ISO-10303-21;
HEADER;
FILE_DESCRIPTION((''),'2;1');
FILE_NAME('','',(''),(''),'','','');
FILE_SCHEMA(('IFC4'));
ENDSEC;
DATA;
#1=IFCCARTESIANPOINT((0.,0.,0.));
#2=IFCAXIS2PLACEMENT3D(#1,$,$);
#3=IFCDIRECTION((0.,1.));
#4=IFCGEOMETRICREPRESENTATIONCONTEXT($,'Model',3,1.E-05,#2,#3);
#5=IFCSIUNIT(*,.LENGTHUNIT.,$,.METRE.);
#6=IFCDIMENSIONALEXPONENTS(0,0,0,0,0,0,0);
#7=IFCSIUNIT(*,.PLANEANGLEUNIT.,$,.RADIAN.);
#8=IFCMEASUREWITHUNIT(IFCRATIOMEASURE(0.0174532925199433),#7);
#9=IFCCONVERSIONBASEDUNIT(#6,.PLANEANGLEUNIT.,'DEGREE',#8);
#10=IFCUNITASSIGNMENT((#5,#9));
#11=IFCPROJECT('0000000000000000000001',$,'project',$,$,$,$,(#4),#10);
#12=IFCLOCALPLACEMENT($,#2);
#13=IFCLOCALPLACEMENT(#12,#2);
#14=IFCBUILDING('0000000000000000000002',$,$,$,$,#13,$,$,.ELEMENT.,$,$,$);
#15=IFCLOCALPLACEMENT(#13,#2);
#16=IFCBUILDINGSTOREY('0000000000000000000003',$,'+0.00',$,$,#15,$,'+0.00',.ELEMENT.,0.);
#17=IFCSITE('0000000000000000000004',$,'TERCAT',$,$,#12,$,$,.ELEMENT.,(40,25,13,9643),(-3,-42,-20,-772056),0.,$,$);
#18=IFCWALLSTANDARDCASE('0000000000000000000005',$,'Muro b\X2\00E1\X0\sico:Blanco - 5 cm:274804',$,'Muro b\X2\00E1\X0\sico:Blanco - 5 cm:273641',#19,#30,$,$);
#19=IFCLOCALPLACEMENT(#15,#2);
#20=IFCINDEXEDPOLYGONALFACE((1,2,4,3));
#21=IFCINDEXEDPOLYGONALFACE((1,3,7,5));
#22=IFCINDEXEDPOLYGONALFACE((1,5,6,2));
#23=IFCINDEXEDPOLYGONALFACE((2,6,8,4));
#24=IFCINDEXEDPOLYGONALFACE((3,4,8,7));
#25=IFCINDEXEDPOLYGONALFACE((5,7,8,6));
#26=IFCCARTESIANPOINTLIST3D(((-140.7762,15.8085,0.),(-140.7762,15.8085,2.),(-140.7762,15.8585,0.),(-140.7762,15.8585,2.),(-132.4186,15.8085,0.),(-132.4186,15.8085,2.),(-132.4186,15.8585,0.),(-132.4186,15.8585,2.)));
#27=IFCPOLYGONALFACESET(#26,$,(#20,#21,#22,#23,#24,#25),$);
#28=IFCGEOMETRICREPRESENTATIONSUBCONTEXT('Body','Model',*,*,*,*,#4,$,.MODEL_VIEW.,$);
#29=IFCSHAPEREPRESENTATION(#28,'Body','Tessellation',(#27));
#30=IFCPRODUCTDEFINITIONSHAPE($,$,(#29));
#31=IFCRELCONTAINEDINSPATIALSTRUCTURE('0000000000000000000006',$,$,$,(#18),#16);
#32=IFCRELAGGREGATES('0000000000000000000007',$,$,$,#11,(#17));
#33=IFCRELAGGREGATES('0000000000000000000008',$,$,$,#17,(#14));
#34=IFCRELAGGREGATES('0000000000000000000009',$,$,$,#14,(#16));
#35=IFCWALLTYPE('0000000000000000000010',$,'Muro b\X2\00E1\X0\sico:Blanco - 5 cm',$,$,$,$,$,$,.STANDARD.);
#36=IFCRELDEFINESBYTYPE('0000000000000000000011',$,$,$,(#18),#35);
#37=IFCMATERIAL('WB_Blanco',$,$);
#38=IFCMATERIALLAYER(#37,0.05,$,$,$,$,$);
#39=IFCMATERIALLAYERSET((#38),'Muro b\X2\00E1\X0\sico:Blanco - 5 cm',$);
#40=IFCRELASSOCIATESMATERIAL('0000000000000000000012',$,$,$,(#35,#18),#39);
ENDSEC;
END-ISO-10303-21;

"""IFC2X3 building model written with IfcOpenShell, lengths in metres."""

from ifc_helpers import new_model, entity, si_unit, converted_unit, direction, frame, frame_2d, origin, place, context, subcontext, project, spatial, rectangle, extrude, material, layer, layer_set, layer_usage, type_object, element, save


model = new_model("IFC2X3")

# Units and contexts
model_context = context("Model", 3, precision=1e-05, world=origin(), true_north=direction((0.0, 1.0)))
body_context = subcontext(model_context, "Body", "Model", "MODEL_VIEW")
ifc_project = project(units=[si_unit("LENGTHUNIT", "METRE"), converted_unit("PLANEANGLEUNIT", "DEGREE", entity("IfcRatioMeasure", 0.0174532925199433), si_unit("PLANEANGLEUNIT", "RADIAN"), dimensions=[0, 0, 0, 0, 0, 0, 0])], contexts=[model_context])

# Site, building, storey
site_placement = place(None, origin())
site = spatial("IfcSite", under=ifc_project, at=site_placement, Name="TERCAT", CompositionType="ELEMENT", RefLatitude=(40, 25, 13, 9643), RefLongitude=(-3, -42, -20, -772056), RefElevation=0.0)
building_placement = place(site_placement, origin())
building = spatial("IfcBuilding", under=site, at=building_placement, CompositionType="ELEMENT")
storey_placement = place(building_placement, origin())
storey = spatial("IfcBuildingStorey", under=building, at=storey_placement, Name="+0.00", LongName="+0.00", CompositionType="ELEMENT", Elevation=0.0)

# Wall
ifc_material_1 = material(Name="WB_Blanco")
ifc_layer_1 = layer(ifc_material_1, 0.05)
ifc_layer_set_1 = layer_set([ifc_layer_1], Name="Muro básico:Blanco - 5 cm")
ifc_layer_usage_1 = layer_usage(ifc_layer_set_1, "AXIS2", "POSITIVE", -0.025)
wall_type_1 = type_object("IfcWallType", Name="Muro básico:Blanco - 5 cm", PredefinedType="STANDARD", material=ifc_layer_set_1)
wall_1_placement = place(storey_placement, frame((-140.7762, 15.8335, 0.0)))
element("IfcWallStandardCase", 1, at=wall_1_placement, inside=storey, type_object=wall_type_1, material=ifc_layer_usage_1, Name="Muro básico:Blanco - 5 cm:274804", ObjectType="Muro básico:Blanco - 5 cm:273641", context=body_context, shape_type="SweptSolid", body=[
    extrude(rectangle(XDim=8.3576, YDim=0.05, at=frame_2d((4.1788, 0.0), x_axis=(-1.0, 0.0))), origin(), (0.0, 0.0, 1.0), 2.0),
])

save(model, "model.ifc")
